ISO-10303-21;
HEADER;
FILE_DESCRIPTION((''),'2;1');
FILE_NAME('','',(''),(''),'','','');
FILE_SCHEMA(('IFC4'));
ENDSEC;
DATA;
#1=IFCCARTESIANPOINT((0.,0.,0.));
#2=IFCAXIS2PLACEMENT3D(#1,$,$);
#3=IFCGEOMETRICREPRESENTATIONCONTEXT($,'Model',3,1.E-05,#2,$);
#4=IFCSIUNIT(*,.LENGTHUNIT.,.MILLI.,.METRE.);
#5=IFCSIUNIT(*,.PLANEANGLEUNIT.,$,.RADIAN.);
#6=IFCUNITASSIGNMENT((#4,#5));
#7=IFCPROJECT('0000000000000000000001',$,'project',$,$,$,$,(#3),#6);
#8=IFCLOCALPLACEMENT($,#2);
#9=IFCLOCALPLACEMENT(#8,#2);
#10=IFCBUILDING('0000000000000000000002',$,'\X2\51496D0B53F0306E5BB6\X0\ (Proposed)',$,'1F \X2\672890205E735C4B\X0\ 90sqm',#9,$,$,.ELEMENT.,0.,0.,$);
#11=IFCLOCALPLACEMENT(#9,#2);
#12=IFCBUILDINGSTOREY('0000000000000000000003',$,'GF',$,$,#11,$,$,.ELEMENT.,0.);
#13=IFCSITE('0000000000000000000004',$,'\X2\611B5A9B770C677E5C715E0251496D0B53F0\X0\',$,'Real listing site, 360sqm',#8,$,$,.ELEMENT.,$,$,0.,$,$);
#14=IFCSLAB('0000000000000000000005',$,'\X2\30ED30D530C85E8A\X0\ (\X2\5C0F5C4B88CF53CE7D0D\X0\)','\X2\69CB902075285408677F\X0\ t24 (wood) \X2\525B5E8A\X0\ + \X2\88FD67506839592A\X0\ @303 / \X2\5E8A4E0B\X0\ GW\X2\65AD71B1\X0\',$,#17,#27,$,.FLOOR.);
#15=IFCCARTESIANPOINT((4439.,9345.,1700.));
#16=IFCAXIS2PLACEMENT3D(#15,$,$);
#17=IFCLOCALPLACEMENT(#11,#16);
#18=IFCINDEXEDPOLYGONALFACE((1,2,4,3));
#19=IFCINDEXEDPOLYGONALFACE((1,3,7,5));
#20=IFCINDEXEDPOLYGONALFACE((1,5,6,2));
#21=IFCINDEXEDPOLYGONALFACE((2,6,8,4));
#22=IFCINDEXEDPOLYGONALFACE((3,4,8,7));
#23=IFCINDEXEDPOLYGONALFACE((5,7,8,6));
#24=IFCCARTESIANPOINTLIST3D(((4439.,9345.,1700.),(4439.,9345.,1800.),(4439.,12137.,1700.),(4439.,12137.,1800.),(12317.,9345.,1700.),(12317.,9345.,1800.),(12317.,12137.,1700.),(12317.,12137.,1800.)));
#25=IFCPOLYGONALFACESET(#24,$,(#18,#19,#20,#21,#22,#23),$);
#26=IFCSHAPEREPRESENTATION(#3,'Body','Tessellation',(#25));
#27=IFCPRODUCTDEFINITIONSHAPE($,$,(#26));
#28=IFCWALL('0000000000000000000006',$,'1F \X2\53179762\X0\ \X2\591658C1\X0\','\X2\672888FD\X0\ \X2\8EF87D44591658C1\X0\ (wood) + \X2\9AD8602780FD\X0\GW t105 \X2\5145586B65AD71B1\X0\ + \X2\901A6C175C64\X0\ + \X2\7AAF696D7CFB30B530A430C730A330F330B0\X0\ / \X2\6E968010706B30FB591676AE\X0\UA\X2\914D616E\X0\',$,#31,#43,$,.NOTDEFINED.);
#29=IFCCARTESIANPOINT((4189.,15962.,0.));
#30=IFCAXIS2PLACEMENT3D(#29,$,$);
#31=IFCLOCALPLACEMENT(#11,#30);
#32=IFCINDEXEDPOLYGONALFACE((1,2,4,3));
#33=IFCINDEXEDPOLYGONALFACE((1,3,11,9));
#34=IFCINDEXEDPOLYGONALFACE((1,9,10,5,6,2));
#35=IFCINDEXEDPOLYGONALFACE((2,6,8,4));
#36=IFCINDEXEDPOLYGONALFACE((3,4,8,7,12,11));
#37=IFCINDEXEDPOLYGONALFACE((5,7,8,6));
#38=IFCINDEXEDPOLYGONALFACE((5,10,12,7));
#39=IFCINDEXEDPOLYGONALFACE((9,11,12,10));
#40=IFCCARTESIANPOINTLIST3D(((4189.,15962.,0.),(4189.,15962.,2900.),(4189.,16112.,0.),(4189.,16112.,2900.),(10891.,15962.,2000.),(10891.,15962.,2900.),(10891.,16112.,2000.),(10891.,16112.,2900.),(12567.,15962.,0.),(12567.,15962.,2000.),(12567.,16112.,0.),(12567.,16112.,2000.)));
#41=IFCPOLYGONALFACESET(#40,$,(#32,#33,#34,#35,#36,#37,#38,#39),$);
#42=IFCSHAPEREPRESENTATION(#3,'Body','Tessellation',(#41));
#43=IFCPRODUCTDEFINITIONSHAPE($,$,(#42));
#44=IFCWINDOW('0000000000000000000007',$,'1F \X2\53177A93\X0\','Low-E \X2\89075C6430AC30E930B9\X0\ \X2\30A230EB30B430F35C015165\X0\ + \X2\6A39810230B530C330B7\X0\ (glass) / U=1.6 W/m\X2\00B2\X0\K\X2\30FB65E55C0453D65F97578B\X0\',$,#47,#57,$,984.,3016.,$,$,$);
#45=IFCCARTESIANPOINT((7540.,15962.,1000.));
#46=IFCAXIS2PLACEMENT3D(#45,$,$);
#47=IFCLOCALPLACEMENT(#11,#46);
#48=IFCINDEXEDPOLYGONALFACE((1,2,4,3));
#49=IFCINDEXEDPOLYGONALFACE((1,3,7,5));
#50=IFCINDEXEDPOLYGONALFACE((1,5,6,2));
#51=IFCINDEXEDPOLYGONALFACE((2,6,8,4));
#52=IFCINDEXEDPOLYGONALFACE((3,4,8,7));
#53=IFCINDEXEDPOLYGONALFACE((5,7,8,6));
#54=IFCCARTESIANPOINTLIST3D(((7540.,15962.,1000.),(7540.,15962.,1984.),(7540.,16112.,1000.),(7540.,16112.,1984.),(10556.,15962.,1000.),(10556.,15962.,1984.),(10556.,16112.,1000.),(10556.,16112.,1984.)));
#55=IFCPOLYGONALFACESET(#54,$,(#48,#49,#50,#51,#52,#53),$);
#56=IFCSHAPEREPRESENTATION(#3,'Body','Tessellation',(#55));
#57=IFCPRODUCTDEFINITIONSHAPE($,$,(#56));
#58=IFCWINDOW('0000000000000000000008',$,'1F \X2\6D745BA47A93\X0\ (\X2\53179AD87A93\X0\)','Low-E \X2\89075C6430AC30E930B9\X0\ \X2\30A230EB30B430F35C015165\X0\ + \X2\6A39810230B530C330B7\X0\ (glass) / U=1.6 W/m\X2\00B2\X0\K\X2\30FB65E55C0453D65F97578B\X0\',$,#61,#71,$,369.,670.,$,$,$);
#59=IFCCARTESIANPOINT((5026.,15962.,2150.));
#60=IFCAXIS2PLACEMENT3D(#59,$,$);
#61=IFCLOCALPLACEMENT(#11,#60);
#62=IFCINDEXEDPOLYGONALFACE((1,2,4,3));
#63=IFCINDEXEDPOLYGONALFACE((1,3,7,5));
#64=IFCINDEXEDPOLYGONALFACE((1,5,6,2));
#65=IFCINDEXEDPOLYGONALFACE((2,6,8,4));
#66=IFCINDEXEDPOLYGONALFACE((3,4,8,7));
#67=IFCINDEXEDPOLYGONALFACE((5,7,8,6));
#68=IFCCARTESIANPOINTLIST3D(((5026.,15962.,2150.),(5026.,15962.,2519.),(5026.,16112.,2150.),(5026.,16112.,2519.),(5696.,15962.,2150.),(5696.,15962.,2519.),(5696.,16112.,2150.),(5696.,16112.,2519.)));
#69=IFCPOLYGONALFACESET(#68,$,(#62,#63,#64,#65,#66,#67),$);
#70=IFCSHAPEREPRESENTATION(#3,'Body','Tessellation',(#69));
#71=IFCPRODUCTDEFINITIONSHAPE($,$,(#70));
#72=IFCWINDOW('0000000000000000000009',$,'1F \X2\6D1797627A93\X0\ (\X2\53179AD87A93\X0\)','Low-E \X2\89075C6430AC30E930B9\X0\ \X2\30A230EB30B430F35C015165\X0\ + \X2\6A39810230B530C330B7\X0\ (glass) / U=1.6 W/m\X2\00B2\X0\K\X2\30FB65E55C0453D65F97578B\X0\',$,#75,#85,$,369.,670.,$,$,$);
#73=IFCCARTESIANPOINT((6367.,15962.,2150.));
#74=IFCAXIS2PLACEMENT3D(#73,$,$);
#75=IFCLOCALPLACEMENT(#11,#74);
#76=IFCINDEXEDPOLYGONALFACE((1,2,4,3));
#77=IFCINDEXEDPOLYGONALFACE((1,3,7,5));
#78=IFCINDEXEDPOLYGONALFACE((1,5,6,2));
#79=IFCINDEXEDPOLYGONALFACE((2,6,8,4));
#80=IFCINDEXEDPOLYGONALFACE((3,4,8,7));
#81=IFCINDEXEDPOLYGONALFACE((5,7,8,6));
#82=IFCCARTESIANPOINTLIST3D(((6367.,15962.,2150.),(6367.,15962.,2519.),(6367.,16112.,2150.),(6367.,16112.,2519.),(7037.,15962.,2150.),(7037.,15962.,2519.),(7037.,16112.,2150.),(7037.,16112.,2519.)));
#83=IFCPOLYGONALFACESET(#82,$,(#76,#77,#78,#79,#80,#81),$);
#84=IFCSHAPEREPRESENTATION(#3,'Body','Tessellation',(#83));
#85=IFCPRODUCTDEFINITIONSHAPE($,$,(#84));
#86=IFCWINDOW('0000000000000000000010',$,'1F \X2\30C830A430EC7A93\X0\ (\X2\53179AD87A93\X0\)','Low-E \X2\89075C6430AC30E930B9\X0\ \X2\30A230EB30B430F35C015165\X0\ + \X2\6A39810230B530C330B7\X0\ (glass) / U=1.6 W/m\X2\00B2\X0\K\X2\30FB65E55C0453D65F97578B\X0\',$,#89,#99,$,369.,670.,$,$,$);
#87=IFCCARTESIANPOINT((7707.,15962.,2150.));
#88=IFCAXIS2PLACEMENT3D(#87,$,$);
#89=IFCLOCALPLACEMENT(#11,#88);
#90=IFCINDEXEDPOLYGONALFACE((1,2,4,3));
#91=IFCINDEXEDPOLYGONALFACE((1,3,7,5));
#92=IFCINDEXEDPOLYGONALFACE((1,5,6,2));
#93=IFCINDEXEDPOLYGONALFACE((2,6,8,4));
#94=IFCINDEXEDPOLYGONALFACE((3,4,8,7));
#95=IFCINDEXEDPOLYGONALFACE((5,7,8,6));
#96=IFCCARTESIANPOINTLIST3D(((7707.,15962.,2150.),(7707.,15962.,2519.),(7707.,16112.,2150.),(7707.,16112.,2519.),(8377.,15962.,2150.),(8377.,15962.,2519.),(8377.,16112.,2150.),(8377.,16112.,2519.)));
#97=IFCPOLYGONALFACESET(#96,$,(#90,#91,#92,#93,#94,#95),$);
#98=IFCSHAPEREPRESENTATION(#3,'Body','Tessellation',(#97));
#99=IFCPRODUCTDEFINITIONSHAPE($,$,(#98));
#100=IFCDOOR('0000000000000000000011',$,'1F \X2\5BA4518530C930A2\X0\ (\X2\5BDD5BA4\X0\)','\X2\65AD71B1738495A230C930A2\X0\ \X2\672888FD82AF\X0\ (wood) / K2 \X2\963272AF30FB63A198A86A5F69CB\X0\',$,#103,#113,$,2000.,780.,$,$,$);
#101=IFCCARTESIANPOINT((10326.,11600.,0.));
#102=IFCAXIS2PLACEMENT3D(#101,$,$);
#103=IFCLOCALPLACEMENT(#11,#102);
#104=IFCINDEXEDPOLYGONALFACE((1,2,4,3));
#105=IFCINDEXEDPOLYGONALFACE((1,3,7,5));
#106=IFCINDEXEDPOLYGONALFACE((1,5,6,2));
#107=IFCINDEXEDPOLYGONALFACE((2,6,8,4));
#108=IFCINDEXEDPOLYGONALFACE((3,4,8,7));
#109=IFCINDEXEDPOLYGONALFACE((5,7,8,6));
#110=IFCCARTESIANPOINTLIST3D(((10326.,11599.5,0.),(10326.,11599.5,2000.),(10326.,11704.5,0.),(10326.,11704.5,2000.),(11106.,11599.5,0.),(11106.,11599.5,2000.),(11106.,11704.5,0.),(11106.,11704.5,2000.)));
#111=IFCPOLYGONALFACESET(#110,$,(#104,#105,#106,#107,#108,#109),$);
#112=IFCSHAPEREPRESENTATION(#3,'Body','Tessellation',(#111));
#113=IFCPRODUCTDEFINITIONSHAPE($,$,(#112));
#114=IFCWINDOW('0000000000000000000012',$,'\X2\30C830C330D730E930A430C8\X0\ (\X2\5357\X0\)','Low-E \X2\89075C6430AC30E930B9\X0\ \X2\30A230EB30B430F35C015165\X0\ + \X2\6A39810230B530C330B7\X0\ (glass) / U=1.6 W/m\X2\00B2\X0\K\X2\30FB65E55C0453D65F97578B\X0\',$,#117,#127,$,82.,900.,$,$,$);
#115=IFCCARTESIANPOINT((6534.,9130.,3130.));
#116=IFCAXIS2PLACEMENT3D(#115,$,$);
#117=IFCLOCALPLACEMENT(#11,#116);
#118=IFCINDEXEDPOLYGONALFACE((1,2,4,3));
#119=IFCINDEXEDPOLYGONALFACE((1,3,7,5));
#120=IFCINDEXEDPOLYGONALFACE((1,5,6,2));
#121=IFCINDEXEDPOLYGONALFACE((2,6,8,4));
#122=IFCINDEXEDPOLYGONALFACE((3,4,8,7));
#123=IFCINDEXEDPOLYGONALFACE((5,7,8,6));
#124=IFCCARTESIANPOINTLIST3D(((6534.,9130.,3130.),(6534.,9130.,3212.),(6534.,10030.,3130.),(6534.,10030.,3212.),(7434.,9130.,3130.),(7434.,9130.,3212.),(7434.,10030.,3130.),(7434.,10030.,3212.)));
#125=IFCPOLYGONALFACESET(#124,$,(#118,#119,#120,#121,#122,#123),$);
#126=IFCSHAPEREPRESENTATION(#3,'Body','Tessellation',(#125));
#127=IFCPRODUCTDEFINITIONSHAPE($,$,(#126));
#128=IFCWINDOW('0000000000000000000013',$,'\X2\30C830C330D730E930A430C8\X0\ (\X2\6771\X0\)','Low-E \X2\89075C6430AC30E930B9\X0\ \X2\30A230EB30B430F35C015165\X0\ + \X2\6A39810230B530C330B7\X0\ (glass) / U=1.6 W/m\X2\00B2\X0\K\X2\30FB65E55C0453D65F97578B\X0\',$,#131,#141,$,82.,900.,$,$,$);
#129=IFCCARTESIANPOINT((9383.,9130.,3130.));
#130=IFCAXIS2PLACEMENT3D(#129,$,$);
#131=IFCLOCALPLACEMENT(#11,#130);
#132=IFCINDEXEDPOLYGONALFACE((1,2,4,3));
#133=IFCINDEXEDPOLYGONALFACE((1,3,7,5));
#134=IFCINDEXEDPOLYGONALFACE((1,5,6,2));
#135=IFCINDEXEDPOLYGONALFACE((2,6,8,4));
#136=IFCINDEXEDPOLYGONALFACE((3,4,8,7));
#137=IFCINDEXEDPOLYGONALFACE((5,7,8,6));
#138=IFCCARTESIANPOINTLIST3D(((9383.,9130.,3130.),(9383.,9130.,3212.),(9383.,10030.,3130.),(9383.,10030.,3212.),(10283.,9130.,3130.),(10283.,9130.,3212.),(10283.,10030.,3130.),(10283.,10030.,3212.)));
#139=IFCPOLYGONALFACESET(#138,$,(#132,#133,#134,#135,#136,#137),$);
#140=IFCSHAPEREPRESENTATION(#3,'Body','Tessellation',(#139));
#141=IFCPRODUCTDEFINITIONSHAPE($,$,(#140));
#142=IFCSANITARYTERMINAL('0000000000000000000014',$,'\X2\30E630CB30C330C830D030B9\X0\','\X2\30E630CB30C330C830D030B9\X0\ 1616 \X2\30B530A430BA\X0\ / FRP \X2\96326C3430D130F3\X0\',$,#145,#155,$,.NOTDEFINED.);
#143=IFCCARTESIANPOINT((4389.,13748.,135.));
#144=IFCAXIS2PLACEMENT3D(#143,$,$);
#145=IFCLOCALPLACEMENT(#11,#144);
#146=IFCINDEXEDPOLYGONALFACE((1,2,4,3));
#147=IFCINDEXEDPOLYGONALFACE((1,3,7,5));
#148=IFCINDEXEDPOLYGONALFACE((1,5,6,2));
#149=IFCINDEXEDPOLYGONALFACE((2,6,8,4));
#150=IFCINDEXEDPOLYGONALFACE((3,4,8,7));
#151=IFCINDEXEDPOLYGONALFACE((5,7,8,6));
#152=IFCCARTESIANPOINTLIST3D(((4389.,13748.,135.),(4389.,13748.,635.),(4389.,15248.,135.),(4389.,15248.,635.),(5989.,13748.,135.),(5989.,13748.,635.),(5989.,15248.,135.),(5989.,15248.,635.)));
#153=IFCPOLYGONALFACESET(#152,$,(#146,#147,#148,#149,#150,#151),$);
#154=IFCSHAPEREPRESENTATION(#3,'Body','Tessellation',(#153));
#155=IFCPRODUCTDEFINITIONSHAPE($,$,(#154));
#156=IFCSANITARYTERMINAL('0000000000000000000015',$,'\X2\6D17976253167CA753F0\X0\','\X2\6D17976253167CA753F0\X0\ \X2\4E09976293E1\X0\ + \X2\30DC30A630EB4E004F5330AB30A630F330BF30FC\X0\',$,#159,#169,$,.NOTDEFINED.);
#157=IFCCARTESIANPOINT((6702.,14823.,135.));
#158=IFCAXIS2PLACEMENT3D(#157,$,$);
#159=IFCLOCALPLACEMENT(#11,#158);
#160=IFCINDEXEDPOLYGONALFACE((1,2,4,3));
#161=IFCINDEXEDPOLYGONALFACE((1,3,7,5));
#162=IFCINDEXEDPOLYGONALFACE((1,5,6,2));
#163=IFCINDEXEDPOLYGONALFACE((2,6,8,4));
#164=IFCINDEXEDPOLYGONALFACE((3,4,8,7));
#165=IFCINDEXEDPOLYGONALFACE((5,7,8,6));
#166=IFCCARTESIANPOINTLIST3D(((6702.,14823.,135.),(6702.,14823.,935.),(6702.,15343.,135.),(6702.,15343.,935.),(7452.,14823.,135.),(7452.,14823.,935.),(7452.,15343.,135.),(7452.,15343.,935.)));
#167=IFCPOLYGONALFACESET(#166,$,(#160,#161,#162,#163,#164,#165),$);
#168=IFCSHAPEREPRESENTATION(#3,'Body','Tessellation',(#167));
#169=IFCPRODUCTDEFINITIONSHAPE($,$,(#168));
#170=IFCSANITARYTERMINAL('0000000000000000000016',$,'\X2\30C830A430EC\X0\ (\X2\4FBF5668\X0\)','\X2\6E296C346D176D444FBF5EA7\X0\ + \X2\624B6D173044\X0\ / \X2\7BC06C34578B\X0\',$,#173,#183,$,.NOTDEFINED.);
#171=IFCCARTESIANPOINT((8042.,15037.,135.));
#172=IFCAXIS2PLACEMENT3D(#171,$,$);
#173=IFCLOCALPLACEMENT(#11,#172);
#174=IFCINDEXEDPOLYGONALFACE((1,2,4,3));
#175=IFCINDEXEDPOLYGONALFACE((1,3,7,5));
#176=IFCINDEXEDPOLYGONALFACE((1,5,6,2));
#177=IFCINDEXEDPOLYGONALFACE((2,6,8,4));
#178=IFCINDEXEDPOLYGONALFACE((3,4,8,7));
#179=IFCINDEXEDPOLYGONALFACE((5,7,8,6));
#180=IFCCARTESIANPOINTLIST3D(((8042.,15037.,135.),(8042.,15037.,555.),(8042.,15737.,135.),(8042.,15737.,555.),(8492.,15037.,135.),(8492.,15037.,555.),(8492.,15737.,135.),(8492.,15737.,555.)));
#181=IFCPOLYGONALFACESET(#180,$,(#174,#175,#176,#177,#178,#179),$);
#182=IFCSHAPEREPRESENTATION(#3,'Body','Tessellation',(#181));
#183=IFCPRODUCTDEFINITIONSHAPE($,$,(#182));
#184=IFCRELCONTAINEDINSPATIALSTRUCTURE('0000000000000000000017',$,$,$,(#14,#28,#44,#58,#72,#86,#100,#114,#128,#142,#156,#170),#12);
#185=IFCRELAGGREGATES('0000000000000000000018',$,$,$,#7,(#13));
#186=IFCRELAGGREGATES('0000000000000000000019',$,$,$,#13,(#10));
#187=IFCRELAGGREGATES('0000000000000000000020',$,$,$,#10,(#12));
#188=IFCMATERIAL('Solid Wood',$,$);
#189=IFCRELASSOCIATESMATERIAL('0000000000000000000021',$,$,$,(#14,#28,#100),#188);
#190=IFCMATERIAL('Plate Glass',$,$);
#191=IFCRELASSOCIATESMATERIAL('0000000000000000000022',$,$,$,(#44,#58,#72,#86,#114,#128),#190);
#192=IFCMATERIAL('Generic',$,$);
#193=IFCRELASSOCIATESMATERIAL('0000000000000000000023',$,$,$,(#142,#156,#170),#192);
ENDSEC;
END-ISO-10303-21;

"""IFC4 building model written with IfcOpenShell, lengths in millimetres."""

from ifc_helpers import new_model, si_unit, frame, frame_2d, origin, place, context, project, spatial, rectangle, extrude, material, element, fill, save


model = new_model("IFC4")

# Units and contexts
model_context = context("Model", 3, precision=1e-05, world=origin())
ifc_project = project(units=[si_unit("LENGTHUNIT", "METRE", prefix="MILLI"), si_unit("PLANEANGLEUNIT", "RADIAN")], contexts=[model_context])

# Site, building, storey
site_placement = place(None, origin())
site = spatial("IfcSite", under=ifc_project, at=site_placement, Name="愛媛県松山市光洋台", ObjectType="Real listing site, 360sqm", CompositionType="ELEMENT", RefElevation=0.0)
building_placement = place(site_placement, origin())
building = spatial("IfcBuilding", under=site, at=building_placement, Name="光洋台の家 (Proposed)", ObjectType="1F 木造平屋 90sqm", CompositionType="ELEMENT", ElevationOfRefHeight=0.0, ElevationOfTerrain=0.0)
storey_placement = place(building_placement, origin())
storey = spatial("IfcBuildingStorey", under=building, at=storey_placement, Name="GF", CompositionType="ELEMENT", Elevation=0.0)

# Slab
ifc_material_1 = material(Name="Solid Wood")
slab_placement = place(storey_placement, frame((4439.0, 9345.0, 1700.0)))
element("IfcSlab", 1, at=slab_placement, inside=storey, material=ifc_material_1, Name="ロフト床 (小屋裏収納)", Description="構造用合板 t24 (wood) 剛床 + 製材根太 @303 / 床下 GW断熱", PredefinedType="FLOOR", context=model_context, shape_type="SweptSolid", body=[
    extrude(rectangle(XDim=7878.0, YDim=2792.0, at=frame_2d((3939.0, 1396.0))), frame((4439.0, 9345.0, 1700.0)), (0.0, 0.0, 1.0), 100.0),
])

# Wall, openings, windows
wall_1_placement = place(storey_placement, frame((4189.0, 15962.0, 0.0)))
wall_1 = element("IfcWall", 2, at=wall_1_placement, inside=storey, material=ifc_material_1, Name="1F 北面 外壁", Description="木製 軸組外壁 (wood) + 高性能GW t105 充填断熱 + 通気層 + 窯業系サイディング / 準耐火・外皮UA配慮", PredefinedType="NOTDEFINED", context=model_context, shape_type="SweptSolid", body=[
    extrude(rectangle(XDim=8378.0, YDim=150.0, at=frame_2d((4189.0, 75.0))), frame((4189.0, 15962.0, 0.0)), (0.0, 0.0, 1.0), 2900.0),
])
opening_1_placement = place(storey_placement, frame((7540.0, 15962.0, 1000.0)))
opening_1 = element("IfcOpeningElement", 3, at=opening_1_placement, cuts=wall_1, PredefinedType="NOTDEFINED", context=model_context, shape_type="SweptSolid", body=[
    extrude(rectangle(XDim=3016.0, YDim=150.0, at=frame_2d((1508.0, 75.0))), frame((7540.0, 15962.0, 1000.0)), (0.0, 0.0, 1.0), 984.0),
])
opening_2_placement = place(storey_placement, frame((5026.0, 15962.0, 2150.0)))
opening_2 = element("IfcOpeningElement", 4, at=opening_2_placement, cuts=wall_1, PredefinedType="NOTDEFINED", context=model_context, shape_type="SweptSolid", body=[
    extrude(rectangle(XDim=670.0, YDim=150.0, at=frame_2d((335.0, 75.0))), frame((5026.0, 15962.0, 2150.0)), (0.0, 0.0, 1.0), 369.0),
])
opening_3_placement = place(storey_placement, frame((6367.0, 15962.0, 2150.0)))
opening_3 = element("IfcOpeningElement", 5, at=opening_3_placement, cuts=wall_1, PredefinedType="NOTDEFINED", context=model_context, shape_type="SweptSolid", body=[
    extrude(rectangle(XDim=670.0, YDim=150.0, at=frame_2d((335.0, 75.0))), frame((6367.0, 15962.0, 2150.0)), (0.0, 0.0, 1.0), 369.0),
])
opening_4_placement = place(storey_placement, frame((7707.0, 15962.0, 2150.0)))
opening_4 = element("IfcOpeningElement", 6, at=opening_4_placement, cuts=wall_1, PredefinedType="NOTDEFINED", context=model_context, shape_type="SweptSolid", body=[
    extrude(rectangle(XDim=670.0, YDim=150.0, at=frame_2d((335.0, 75.0))), frame((7707.0, 15962.0, 2150.0)), (0.0, 0.0, 1.0), 369.0),
])
ifc_material_2 = material(Name="Plate Glass")
window_1_placement = place(storey_placement, frame((7540.0, 15962.0, 1000.0)))
window_1 = element("IfcWindow", 7, at=window_1_placement, inside=storey, material=ifc_material_2, Name="1F 北窓", Description="Low-E 複層ガラス アルゴン封入 + 樹脂サッシ (glass) / U=1.6 W/m²K・日射取得型", OverallHeight=984.0, OverallWidth=3016.0, context=model_context, shape_type="SweptSolid", body=[
    extrude(rectangle(XDim=3016.0, YDim=150.0, at=frame_2d((1508.0, 75.0))), frame((7540.0, 15962.0, 1000.0)), (0.0, 0.0, 1.0), 984.0),
])
fill(opening_1, window_1)
window_2_placement = place(storey_placement, frame((5026.0, 15962.0, 2150.0)))
window_2 = element("IfcWindow", 8, at=window_2_placement, inside=storey, material=ifc_material_2, Name="1F 浴室窓 (北高窓)", Description="Low-E 複層ガラス アルゴン封入 + 樹脂サッシ (glass) / U=1.6 W/m²K・日射取得型", OverallHeight=369.0, OverallWidth=670.0, context=model_context, shape_type="SweptSolid", body=[
    extrude(rectangle(XDim=670.0, YDim=150.0, at=frame_2d((335.0, 75.0))), frame((5026.0, 15962.0, 2150.0)), (0.0, 0.0, 1.0), 369.0),
])
fill(opening_2, window_2)
window_3_placement = place(storey_placement, frame((6367.0, 15962.0, 2150.0)))
window_3 = element("IfcWindow", 9, at=window_3_placement, inside=storey, material=ifc_material_2, Name="1F 洗面窓 (北高窓)", Description="Low-E 複層ガラス アルゴン封入 + 樹脂サッシ (glass) / U=1.6 W/m²K・日射取得型", OverallHeight=369.0, OverallWidth=670.0, context=model_context, shape_type="SweptSolid", body=[
    extrude(rectangle(XDim=670.0, YDim=150.0, at=frame_2d((335.0, 75.0))), frame((6367.0, 15962.0, 2150.0)), (0.0, 0.0, 1.0), 369.0),
])
fill(opening_3, window_3)
window_4_placement = place(storey_placement, frame((7707.0, 15962.0, 2150.0)))
window_4 = element("IfcWindow", 10, at=window_4_placement, inside=storey, material=ifc_material_2, Name="1F トイレ窓 (北高窓)", Description="Low-E 複層ガラス アルゴン封入 + 樹脂サッシ (glass) / U=1.6 W/m²K・日射取得型", OverallHeight=369.0, OverallWidth=670.0, context=model_context, shape_type="SweptSolid", body=[
    extrude(rectangle(XDim=670.0, YDim=150.0, at=frame_2d((335.0, 75.0))), frame((7707.0, 15962.0, 2150.0)), (0.0, 0.0, 1.0), 369.0),
])
fill(opening_4, window_4)

# Door
door_1_placement = place(storey_placement, frame((10326.0, 11600.0, 0.0)))
element("IfcDoor", 11, at=door_1_placement, inside=storey, material=ifc_material_1, Name="1F 室内ドア (寝室)", Description="断熱玄関ドア 木製芯 (wood) / K2 防犯・採風機構", OverallHeight=2000.0, OverallWidth=780.0, context=model_context, shape_type="SweptSolid", body=[
    extrude(rectangle(XDim=780.0, YDim=105.0, at=frame_2d((390.0, 52.0))), frame((10326.0, 11600.0, 0.0)), (0.0, 0.0, 1.0), 2000.0),
])

# Windows
window_5_placement = place(storey_placement, frame((6534.0, 9130.0, 3130.0)))
element("IfcWindow", 12, at=window_5_placement, inside=storey, material=ifc_material_2, Name="トップライト (南)", Description="Low-E 複層ガラス アルゴン封入 + 樹脂サッシ (glass) / U=1.6 W/m²K・日射取得型", OverallHeight=82.0, OverallWidth=900.0, context=model_context, shape_type="SweptSolid", body=[
    extrude(rectangle(XDim=900.0, YDim=900.0, at=frame_2d((450.0, 450.0))), frame((6534.0, 9130.0, 3130.0)), (0.0, 0.0, 1.0), 82.0),
])
window_6_placement = place(storey_placement, frame((9383.0, 9130.0, 3130.0)))
element("IfcWindow", 13, at=window_6_placement, inside=storey, material=ifc_material_2, Name="トップライト (東)", Description="Low-E 複層ガラス アルゴン封入 + 樹脂サッシ (glass) / U=1.6 W/m²K・日射取得型", OverallHeight=82.0, OverallWidth=900.0, context=model_context, shape_type="SweptSolid", body=[
    extrude(rectangle(XDim=900.0, YDim=900.0, at=frame_2d((450.0, 450.0))), frame((9383.0, 9130.0, 3130.0)), (0.0, 0.0, 1.0), 82.0),
])

# Sanitary terminals
ifc_material_3 = material(Name="Generic")
sanitary_terminal_1_placement = place(storey_placement, frame((4389.0, 13748.0, 135.0)))
element("IfcSanitaryTerminal", 14, at=sanitary_terminal_1_placement, inside=storey, material=ifc_material_3, Name="ユニットバス", Description="ユニットバス 1616 サイズ / FRP 防水パン", PredefinedType="NOTDEFINED", context=model_context, shape_type="SweptSolid", body=[
    extrude(rectangle(XDim=1600.0, YDim=1500.0, at=frame_2d((800.0, 750.0))), frame((4389.0, 13748.0, 135.0)), (0.0, 0.0, 1.0), 500.0),
])
sanitary_terminal_2_placement = place(storey_placement, frame((6702.0, 14823.0, 135.0)))
element("IfcSanitaryTerminal", 15, at=sanitary_terminal_2_placement, inside=storey, material=ifc_material_3, Name="洗面化粧台", Description="洗面化粧台 三面鏡 + ボウル一体カウンター", PredefinedType="NOTDEFINED", context=model_context, shape_type="SweptSolid", body=[
    extrude(rectangle(XDim=750.0, YDim=520.0, at=frame_2d((375.0, 260.0))), frame((6702.0, 14823.0, 135.0)), (0.0, 0.0, 1.0), 800.0),
])
sanitary_terminal_3_placement = place(storey_placement, frame((8042.0, 15037.0, 135.0)))
element("IfcSanitaryTerminal", 16, at=sanitary_terminal_3_placement, inside=storey, material=ifc_material_3, Name="トイレ (便器)", Description="温水洗浄便座 + 手洗い / 節水型", PredefinedType="NOTDEFINED", context=model_context, shape_type="SweptSolid", body=[
    extrude(rectangle(XDim=450.0, YDim=700.0, at=frame_2d((225.0, 350.0))), frame((8042.0, 15037.0, 135.0)), (0.0, 0.0, 1.0), 420.0),
])

save(model, "model.ifc")
